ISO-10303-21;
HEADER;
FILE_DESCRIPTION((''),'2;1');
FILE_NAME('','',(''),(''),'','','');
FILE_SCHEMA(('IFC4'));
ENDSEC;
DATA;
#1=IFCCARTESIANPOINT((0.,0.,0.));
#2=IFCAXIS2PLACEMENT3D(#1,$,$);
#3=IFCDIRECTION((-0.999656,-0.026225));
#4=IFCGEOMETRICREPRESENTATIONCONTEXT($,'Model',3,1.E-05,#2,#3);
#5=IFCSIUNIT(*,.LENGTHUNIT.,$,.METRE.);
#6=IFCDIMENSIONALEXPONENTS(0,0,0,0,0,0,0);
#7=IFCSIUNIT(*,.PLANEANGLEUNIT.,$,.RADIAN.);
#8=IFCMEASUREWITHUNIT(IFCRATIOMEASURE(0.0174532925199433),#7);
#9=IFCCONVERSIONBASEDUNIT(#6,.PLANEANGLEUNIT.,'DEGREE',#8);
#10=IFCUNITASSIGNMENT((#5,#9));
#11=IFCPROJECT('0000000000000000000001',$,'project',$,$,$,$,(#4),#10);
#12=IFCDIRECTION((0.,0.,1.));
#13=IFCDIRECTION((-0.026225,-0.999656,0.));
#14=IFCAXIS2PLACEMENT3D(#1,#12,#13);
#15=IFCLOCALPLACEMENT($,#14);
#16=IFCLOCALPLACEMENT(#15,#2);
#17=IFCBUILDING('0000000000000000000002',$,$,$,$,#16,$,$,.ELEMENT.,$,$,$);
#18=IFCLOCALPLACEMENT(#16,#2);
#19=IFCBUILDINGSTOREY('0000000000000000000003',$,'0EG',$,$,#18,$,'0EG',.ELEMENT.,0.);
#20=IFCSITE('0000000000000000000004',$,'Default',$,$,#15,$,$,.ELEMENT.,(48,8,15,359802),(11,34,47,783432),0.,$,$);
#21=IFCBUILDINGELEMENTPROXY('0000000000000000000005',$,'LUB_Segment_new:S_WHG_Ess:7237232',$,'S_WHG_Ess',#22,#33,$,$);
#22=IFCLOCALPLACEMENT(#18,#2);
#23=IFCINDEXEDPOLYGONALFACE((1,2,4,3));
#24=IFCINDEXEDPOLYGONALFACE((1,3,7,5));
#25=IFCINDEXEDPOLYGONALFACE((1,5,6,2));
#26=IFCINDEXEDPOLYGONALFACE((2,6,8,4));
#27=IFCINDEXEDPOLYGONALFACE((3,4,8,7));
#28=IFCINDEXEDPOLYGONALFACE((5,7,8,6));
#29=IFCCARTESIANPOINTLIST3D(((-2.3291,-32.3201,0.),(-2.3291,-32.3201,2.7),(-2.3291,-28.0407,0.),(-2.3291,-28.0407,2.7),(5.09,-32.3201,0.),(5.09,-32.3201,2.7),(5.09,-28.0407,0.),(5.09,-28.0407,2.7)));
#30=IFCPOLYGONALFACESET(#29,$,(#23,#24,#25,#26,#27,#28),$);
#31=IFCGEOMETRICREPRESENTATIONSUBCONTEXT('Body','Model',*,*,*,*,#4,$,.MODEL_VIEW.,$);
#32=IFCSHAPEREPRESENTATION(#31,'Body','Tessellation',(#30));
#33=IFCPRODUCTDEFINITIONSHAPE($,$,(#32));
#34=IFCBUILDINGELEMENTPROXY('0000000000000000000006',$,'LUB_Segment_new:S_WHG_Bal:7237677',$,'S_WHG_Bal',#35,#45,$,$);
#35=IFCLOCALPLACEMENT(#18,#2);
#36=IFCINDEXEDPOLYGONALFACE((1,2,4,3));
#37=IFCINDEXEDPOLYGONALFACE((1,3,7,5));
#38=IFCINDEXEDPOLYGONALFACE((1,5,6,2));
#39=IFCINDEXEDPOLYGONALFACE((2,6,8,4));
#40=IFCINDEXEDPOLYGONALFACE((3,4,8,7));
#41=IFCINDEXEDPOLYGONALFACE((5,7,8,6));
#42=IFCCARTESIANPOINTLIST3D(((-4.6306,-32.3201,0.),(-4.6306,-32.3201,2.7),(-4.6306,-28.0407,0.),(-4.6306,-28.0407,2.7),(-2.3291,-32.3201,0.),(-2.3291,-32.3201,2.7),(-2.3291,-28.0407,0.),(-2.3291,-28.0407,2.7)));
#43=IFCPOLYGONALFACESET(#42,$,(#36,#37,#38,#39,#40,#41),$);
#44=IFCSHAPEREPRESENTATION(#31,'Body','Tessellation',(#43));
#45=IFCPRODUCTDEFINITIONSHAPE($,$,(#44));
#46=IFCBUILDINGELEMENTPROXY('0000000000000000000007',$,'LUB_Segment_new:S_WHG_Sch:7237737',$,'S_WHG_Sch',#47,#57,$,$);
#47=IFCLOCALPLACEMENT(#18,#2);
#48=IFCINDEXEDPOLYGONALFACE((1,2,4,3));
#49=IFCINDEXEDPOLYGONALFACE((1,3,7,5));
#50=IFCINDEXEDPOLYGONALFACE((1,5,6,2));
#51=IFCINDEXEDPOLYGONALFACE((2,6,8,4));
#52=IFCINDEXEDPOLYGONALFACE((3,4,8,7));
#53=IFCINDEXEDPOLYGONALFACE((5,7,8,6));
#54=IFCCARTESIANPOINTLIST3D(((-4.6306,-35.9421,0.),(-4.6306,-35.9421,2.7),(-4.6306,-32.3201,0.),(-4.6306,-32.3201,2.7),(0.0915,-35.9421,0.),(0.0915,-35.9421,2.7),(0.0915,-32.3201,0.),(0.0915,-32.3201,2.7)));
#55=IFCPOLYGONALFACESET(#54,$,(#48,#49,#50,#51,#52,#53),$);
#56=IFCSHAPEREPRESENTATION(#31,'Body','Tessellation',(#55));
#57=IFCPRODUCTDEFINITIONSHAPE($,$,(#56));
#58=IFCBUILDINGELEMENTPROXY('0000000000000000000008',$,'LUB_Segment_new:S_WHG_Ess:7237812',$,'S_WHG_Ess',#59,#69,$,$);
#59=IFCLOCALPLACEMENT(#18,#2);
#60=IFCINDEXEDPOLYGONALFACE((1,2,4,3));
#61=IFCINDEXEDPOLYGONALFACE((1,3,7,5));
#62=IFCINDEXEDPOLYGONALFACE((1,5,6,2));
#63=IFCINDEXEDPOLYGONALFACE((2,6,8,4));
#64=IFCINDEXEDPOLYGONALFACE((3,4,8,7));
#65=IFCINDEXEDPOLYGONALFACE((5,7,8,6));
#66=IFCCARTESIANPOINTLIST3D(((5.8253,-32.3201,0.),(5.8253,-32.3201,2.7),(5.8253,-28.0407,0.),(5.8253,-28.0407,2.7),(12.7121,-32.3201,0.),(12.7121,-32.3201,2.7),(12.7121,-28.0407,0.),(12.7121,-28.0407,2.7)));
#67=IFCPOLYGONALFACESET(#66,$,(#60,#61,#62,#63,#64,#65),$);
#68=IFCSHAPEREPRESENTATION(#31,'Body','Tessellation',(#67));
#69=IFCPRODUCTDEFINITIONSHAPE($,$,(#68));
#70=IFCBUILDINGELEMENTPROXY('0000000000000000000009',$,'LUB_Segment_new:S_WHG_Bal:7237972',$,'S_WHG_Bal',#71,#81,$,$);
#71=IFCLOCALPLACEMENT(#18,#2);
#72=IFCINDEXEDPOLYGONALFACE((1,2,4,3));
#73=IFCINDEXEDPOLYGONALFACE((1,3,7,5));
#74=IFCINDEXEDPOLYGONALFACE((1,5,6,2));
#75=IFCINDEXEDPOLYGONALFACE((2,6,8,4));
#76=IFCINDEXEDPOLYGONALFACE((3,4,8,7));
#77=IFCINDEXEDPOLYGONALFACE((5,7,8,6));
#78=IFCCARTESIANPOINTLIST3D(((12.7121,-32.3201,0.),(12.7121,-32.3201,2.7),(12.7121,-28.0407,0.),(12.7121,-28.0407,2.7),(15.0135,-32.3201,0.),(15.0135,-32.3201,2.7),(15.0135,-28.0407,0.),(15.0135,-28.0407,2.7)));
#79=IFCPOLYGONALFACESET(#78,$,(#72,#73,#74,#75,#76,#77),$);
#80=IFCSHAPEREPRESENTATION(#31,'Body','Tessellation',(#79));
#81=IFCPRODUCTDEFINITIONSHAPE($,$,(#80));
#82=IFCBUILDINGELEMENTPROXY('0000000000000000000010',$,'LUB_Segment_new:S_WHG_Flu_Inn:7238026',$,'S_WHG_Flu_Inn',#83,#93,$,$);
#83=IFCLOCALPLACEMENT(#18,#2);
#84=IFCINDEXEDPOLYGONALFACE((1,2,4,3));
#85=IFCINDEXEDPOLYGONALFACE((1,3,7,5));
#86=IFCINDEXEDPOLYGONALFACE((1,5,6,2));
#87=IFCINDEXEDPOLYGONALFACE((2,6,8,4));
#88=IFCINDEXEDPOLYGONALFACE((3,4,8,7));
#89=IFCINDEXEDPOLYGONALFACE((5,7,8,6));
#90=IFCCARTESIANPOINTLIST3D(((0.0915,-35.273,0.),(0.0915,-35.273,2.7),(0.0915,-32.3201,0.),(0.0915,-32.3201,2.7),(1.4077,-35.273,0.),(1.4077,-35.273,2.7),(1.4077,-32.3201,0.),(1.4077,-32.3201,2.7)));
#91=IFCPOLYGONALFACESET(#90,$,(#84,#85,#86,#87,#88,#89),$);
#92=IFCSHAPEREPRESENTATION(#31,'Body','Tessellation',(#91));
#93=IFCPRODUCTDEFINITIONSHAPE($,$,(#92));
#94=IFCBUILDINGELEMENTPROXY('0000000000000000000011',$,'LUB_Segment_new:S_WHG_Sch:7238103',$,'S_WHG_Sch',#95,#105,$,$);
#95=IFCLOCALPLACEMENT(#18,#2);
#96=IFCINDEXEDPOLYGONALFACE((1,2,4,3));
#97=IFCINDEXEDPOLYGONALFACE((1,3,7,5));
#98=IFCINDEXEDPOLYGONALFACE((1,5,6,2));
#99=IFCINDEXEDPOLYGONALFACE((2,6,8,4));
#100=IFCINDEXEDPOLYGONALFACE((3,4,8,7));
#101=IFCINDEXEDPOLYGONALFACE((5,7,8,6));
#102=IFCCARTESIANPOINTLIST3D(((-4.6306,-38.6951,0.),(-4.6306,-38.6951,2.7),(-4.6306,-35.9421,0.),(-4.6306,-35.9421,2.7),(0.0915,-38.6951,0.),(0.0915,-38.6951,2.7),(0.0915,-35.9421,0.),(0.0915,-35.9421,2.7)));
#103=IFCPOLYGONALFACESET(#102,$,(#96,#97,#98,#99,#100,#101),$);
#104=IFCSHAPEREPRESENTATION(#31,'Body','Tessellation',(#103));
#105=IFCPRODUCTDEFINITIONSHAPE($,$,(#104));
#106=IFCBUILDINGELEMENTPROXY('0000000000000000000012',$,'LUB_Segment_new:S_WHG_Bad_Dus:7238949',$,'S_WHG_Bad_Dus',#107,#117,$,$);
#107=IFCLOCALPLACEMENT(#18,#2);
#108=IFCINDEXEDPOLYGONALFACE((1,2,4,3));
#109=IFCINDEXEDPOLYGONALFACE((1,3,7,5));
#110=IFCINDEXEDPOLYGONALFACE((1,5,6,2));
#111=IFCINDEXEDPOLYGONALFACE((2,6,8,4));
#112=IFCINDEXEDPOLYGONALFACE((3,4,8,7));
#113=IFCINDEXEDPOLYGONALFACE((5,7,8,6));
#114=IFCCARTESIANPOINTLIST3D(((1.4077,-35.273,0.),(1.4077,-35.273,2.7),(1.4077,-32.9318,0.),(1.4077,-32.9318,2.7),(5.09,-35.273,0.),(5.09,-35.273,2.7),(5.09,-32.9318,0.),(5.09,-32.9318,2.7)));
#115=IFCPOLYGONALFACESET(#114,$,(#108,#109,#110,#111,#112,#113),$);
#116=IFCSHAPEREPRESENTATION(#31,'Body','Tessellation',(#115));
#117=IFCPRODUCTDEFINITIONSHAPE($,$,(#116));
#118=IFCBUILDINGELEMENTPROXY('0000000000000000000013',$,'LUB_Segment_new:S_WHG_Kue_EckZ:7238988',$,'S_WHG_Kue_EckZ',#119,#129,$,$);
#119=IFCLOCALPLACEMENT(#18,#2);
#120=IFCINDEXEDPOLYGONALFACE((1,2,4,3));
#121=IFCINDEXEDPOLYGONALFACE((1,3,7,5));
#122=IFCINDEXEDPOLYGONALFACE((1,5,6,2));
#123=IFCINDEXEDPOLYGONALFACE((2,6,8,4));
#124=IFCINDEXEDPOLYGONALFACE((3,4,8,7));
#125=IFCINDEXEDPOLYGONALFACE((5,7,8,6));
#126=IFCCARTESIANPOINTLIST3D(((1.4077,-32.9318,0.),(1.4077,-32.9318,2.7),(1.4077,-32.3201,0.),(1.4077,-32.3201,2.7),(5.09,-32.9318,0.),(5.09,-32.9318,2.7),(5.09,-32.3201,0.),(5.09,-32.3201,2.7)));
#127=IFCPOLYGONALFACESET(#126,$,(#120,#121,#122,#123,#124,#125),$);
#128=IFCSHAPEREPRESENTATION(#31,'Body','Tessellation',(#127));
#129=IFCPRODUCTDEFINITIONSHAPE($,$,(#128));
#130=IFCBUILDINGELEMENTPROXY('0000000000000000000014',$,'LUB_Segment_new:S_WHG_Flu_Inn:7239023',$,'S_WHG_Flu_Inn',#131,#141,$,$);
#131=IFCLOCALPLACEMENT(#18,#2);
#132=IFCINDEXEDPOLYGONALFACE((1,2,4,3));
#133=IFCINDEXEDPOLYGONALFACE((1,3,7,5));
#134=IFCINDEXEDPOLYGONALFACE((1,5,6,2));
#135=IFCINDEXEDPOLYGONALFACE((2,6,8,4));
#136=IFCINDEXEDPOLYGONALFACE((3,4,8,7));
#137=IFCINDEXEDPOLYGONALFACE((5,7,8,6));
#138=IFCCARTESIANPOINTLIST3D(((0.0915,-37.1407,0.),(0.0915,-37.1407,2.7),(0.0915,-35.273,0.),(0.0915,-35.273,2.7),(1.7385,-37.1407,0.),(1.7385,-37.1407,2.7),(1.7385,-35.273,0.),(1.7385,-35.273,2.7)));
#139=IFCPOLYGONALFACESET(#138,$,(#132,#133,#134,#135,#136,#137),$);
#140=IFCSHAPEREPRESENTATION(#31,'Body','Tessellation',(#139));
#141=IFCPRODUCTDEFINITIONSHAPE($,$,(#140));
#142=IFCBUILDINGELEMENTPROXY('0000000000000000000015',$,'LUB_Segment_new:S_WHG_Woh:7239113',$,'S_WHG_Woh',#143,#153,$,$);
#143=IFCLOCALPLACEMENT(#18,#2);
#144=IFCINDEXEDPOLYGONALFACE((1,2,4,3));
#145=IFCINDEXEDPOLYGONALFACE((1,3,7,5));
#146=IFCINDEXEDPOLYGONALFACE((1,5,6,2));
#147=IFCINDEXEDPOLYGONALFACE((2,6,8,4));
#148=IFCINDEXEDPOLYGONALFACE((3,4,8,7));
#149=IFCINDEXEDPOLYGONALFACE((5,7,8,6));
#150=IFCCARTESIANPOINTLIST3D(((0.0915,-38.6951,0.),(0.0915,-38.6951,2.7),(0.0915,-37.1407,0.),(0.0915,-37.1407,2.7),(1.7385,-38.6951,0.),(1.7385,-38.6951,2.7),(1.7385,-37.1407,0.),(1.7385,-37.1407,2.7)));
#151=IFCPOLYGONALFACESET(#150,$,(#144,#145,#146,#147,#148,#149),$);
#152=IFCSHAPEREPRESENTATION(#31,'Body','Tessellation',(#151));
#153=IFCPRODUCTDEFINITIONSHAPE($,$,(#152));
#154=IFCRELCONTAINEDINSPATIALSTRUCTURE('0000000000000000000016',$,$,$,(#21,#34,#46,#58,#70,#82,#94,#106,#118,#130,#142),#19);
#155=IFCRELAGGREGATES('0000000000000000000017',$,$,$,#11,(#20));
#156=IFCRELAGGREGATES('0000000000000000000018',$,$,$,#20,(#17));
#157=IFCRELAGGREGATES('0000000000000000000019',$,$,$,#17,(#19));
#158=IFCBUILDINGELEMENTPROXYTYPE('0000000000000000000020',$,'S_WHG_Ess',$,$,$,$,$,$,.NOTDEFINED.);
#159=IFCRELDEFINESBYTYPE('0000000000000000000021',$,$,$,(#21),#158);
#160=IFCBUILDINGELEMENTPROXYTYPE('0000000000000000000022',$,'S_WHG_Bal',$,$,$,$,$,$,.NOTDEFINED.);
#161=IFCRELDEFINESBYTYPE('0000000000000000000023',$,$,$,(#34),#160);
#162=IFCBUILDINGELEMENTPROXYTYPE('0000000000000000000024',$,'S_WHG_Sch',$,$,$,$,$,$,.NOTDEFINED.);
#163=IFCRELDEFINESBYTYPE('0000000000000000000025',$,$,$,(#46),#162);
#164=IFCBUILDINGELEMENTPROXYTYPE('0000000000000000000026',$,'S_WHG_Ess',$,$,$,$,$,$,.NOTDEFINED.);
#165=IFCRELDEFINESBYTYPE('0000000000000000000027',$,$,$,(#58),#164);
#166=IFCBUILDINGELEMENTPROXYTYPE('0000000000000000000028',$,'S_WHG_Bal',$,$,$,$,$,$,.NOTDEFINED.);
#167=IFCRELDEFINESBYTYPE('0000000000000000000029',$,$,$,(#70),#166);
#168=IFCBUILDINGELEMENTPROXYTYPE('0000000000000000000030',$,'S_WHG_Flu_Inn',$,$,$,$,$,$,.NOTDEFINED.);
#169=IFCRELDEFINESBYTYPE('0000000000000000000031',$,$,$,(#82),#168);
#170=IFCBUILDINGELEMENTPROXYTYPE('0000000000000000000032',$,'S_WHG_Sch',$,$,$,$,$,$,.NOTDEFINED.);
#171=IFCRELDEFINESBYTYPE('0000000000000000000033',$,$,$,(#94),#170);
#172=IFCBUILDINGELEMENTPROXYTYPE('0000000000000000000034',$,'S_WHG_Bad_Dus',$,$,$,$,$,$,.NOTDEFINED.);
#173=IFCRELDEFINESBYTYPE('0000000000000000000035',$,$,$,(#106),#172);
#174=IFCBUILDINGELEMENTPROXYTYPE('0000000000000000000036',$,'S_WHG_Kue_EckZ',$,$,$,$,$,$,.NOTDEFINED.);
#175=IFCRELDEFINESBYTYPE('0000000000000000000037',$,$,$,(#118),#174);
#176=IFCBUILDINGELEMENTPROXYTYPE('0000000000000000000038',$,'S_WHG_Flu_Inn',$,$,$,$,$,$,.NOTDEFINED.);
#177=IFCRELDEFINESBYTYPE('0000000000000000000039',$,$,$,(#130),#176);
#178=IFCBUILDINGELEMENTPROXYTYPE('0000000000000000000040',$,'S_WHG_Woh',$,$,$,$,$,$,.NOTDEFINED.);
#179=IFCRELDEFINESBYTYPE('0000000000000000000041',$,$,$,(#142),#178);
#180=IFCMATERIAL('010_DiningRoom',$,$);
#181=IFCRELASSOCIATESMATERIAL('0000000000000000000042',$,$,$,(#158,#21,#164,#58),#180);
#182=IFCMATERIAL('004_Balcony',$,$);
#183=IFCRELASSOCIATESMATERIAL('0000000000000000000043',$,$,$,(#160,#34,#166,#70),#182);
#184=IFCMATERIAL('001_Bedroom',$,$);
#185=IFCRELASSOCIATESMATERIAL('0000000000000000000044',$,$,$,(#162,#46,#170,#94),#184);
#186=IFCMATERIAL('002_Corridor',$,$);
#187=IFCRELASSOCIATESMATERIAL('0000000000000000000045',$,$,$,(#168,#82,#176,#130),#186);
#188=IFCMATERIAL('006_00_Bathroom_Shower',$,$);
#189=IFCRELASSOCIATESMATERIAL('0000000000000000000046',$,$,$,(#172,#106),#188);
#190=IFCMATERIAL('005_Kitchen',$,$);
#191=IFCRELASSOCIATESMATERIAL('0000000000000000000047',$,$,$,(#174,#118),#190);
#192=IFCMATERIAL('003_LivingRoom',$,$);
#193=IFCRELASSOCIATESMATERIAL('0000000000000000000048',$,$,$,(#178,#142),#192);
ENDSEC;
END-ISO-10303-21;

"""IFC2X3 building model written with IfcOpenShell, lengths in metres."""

from ifc_helpers import new_model, entity, si_unit, converted_unit, direction, frame, origin, origin_2d_with_axis, place, context, subcontext, project, spatial, rectangle, extrude, source, transform, mapped, material, type_object, type_shapes, element, save


model = new_model("IFC2X3")

# Units and contexts
model_context = context("Model", 3, precision=1e-05, world=origin(), true_north=direction((-0.999656, -0.026225)))
body_context = subcontext(model_context, "Body", "Model", "MODEL_VIEW")
ifc_project = project(units=[si_unit("LENGTHUNIT", "METRE"), converted_unit("PLANEANGLEUNIT", "DEGREE", entity("IfcRatioMeasure", 0.0174532925199433), si_unit("PLANEANGLEUNIT", "RADIAN"), dimensions=[0, 0, 0, 0, 0, 0, 0])], contexts=[model_context])

# Site, building, storey
site_placement = place(None, frame((0.0, 0.0, 0.0), z_axis=(0.0, 0.0, 1.0), x_axis=(-0.026225, -0.999656, 0.0)))
site = spatial("IfcSite", under=ifc_project, at=site_placement, Name="Default", CompositionType="ELEMENT", RefLatitude=(48, 8, 15, 359802), RefLongitude=(11, 34, 47, 783432), RefElevation=0.0)
building_placement = place(site_placement, origin())
building = spatial("IfcBuilding", under=site, at=building_placement, CompositionType="ELEMENT")
storey_placement = place(building_placement, origin())
storey = spatial("IfcBuildingStorey", under=building, at=storey_placement, Name="0EG", LongName="0EG", CompositionType="ELEMENT", Elevation=0.0)

# Building element proxies
ifc_material_1 = material(Name="010_DiningRoom")
building_element_proxy_type_1 = type_object("IfcBuildingElementProxyType", Name="S_WHG_Ess", PredefinedType="NOTDEFINED", material=ifc_material_1)
shared_shape_1 = source(origin(), body_context, "Body", "SweptSolid", [
    extrude(rectangle(XDim=7.4191, YDim=4.2794, at=origin_2d_with_axis()), frame((0.0, 0.0, 0.0), z_axis=(0.0, 0.0, 1.0), x_axis=(-1.0, 0.0, 0.0)), (0.0, 0.0, 1.0), 2.7),
])
type_shapes(building_element_proxy_type_1, [shared_shape_1])
proxy_1_placement = place(storey_placement, frame((1.3805, -30.1804, 0.0)))
element("IfcBuildingElementProxy", 1, at=proxy_1_placement, inside=storey, type_object=building_element_proxy_type_1, material=ifc_material_1, Name="LUB_Segment_new:S_WHG_Ess:7237232", ObjectType="S_WHG_Ess", context=body_context, shape_type="MappedRepresentation", body=[
    mapped(shared_shape_1, transform((0.0, 0.0, 0.0), scale=1.0)),
])
ifc_material_2 = material(Name="004_Balcony")
building_element_proxy_type_2 = type_object("IfcBuildingElementProxyType", Name="S_WHG_Bal", PredefinedType="NOTDEFINED", material=ifc_material_2)
shared_shape_2 = source(origin(), body_context, "Body", "SweptSolid", [
    extrude(rectangle(XDim=2.3015, YDim=4.2794, at=origin_2d_with_axis()), frame((0.0, 0.0, 0.0), z_axis=(0.0, 0.0, 1.0), x_axis=(-1.0, 0.0, 0.0)), (0.0, 0.0, 1.0), 2.7),
])
type_shapes(building_element_proxy_type_2, [shared_shape_2])
proxy_2_placement = place(storey_placement, frame((-3.4798, -30.1804, 0.0)))
element("IfcBuildingElementProxy", 2, at=proxy_2_placement, inside=storey, type_object=building_element_proxy_type_2, material=ifc_material_2, Name="LUB_Segment_new:S_WHG_Bal:7237677", ObjectType="S_WHG_Bal", context=body_context, shape_type="MappedRepresentation", body=[
    mapped(shared_shape_2, transform((0.0, 0.0, 0.0), scale=1.0)),
])
ifc_material_3 = material(Name="001_Bedroom")
building_element_proxy_type_3 = type_object("IfcBuildingElementProxyType", Name="S_WHG_Sch", PredefinedType="NOTDEFINED", material=ifc_material_3)
shared_shape_3 = source(origin(), body_context, "Body", "SweptSolid", [
    extrude(rectangle(XDim=4.7221, YDim=3.6221, at=origin_2d_with_axis()), frame((0.0, 0.0, 0.0), z_axis=(0.0, 0.0, 1.0), x_axis=(-1.0, 0.0, 0.0)), (0.0, 0.0, 1.0), 2.7),
])
type_shapes(building_element_proxy_type_3, [shared_shape_3])
proxy_3_placement = place(storey_placement, frame((-2.2695, -34.1311, 0.0)))
element("IfcBuildingElementProxy", 3, at=proxy_3_placement, inside=storey, type_object=building_element_proxy_type_3, material=ifc_material_3, Name="LUB_Segment_new:S_WHG_Sch:7237737", ObjectType="S_WHG_Sch", context=body_context, shape_type="MappedRepresentation", body=[
    mapped(shared_shape_3, transform((0.0, 0.0, 0.0), scale=1.0)),
])
building_element_proxy_type_4 = type_object("IfcBuildingElementProxyType", Name="S_WHG_Ess", PredefinedType="NOTDEFINED", material=ifc_material_1)
shared_shape_4 = source(origin(), body_context, "Body", "SweptSolid", [
    extrude(rectangle(XDim=6.8868, YDim=4.2794, at=origin_2d_with_axis()), frame((0.0, 0.0, 0.0), z_axis=(0.0, 0.0, 1.0), x_axis=(-1.0, 0.0, 0.0)), (0.0, 0.0, 1.0), 2.7),
])
type_shapes(building_element_proxy_type_4, [shared_shape_4])
proxy_4_placement = place(storey_placement, frame((9.2687, -30.1804, 0.0)))
element("IfcBuildingElementProxy", 4, at=proxy_4_placement, inside=storey, type_object=building_element_proxy_type_4, material=ifc_material_1, Name="LUB_Segment_new:S_WHG_Ess:7237812", ObjectType="S_WHG_Ess", context=body_context, shape_type="MappedRepresentation", body=[
    mapped(shared_shape_4, transform((0.0, 0.0, 0.0), scale=1.0)),
])
building_element_proxy_type_5 = type_object("IfcBuildingElementProxyType", Name="S_WHG_Bal", PredefinedType="NOTDEFINED", material=ifc_material_2)
shared_shape_5 = source(origin(), body_context, "Body", "SweptSolid", [
    extrude(rectangle(XDim=4.2794, YDim=2.3015, at=origin_2d_with_axis()), frame((0.0, 0.0, 0.0), z_axis=(0.0, 0.0, 1.0), x_axis=(0.0, 1.0, 0.0)), (0.0, 0.0, 1.0), 2.7),
])
type_shapes(building_element_proxy_type_5, [shared_shape_5])
proxy_5_placement = place(storey_placement, frame((13.8628, -30.1804, 0.0), z_axis=(0.0, 0.0, 1.0), x_axis=(-1.0, 0.0, 0.0)))
element("IfcBuildingElementProxy", 5, at=proxy_5_placement, inside=storey, type_object=building_element_proxy_type_5, material=ifc_material_2, Name="LUB_Segment_new:S_WHG_Bal:7237972", ObjectType="S_WHG_Bal", context=body_context, shape_type="MappedRepresentation", body=[
    mapped(shared_shape_5, transform((0.0, 0.0, 0.0), scale=1.0)),
])
ifc_material_4 = material(Name="002_Corridor")
building_element_proxy_type_6 = type_object("IfcBuildingElementProxyType", Name="S_WHG_Flu_Inn", PredefinedType="NOTDEFINED", material=ifc_material_4)
shared_shape_6 = source(origin(), body_context, "Body", "SweptSolid", [
    extrude(rectangle(XDim=1.3162, YDim=2.9529, at=origin_2d_with_axis()), frame((0.0, 0.0, 0.0), z_axis=(0.0, 0.0, 1.0), x_axis=(-1.0, 0.0, 0.0)), (0.0, 0.0, 1.0), 2.7),
])
type_shapes(building_element_proxy_type_6, [shared_shape_6])
proxy_6_placement = place(storey_placement, frame((0.7496, -33.7966, 0.0)))
element("IfcBuildingElementProxy", 6, at=proxy_6_placement, inside=storey, type_object=building_element_proxy_type_6, material=ifc_material_4, Name="LUB_Segment_new:S_WHG_Flu_Inn:7238026", ObjectType="S_WHG_Flu_Inn", context=body_context, shape_type="MappedRepresentation", body=[
    mapped(shared_shape_6, transform((0.0, 0.0, 0.0), scale=1.0)),
])
building_element_proxy_type_7 = type_object("IfcBuildingElementProxyType", Name="S_WHG_Sch", PredefinedType="NOTDEFINED", material=ifc_material_3)
shared_shape_7 = source(origin(), body_context, "Body", "SweptSolid", [
    extrude(rectangle(XDim=4.7221, YDim=2.7529, at=origin_2d_with_axis()), frame((0.0, 0.0, 0.0), z_axis=(0.0, 0.0, 1.0), x_axis=(-1.0, 0.0, 0.0)), (0.0, 0.0, 1.0), 2.7),
])
type_shapes(building_element_proxy_type_7, [shared_shape_7])
proxy_7_placement = place(storey_placement, frame((-2.2695, -37.3186, 0.0)))
element("IfcBuildingElementProxy", 7, at=proxy_7_placement, inside=storey, type_object=building_element_proxy_type_7, material=ifc_material_3, Name="LUB_Segment_new:S_WHG_Sch:7238103", ObjectType="S_WHG_Sch", context=body_context, shape_type="MappedRepresentation", body=[
    mapped(shared_shape_7, transform((0.0, 0.0, 0.0), scale=1.0)),
])
ifc_material_5 = material(Name="006_00_Bathroom_Shower")
building_element_proxy_type_8 = type_object("IfcBuildingElementProxyType", Name="S_WHG_Bad_Dus", PredefinedType="NOTDEFINED", material=ifc_material_5)
shared_shape_8 = source(origin(), body_context, "Body", "SweptSolid", [
    extrude(rectangle(XDim=2.3412, YDim=3.6824, at=origin_2d_with_axis()), frame((0.0, 0.0, 0.0), z_axis=(0.0, 0.0, 1.0), x_axis=(0.0, 1.0, 0.0)), (0.0, 0.0, 1.0), 2.7),
])
type_shapes(building_element_proxy_type_8, [shared_shape_8])
proxy_8_placement = place(storey_placement, frame((3.2488, -34.1024, 0.0)))
element("IfcBuildingElementProxy", 8, at=proxy_8_placement, inside=storey, type_object=building_element_proxy_type_8, material=ifc_material_5, Name="LUB_Segment_new:S_WHG_Bad_Dus:7238949", ObjectType="S_WHG_Bad_Dus", context=body_context, shape_type="MappedRepresentation", body=[
    mapped(shared_shape_8, transform((0.0, 0.0, 0.0), scale=1.0)),
])
ifc_material_6 = material(Name="005_Kitchen")
building_element_proxy_type_9 = type_object("IfcBuildingElementProxyType", Name="S_WHG_Kue_EckZ", PredefinedType="NOTDEFINED", material=ifc_material_6)
shared_shape_9 = source(origin(), body_context, "Body", "SweptSolid", [
    extrude(rectangle(XDim=0.6118, YDim=3.6824, at=origin_2d_with_axis()), frame((0.0, 0.0, 0.0), z_axis=(0.0, 0.0, 1.0), x_axis=(0.0, 1.0, 0.0)), (0.0, 0.0, 1.0), 2.7),
])
type_shapes(building_element_proxy_type_9, [shared_shape_9])
proxy_9_placement = place(storey_placement, frame((3.2488, -32.626, 0.0)))
element("IfcBuildingElementProxy", 9, at=proxy_9_placement, inside=storey, type_object=building_element_proxy_type_9, material=ifc_material_6, Name="LUB_Segment_new:S_WHG_Kue_EckZ:7238988", ObjectType="S_WHG_Kue_EckZ", context=body_context, shape_type="MappedRepresentation", body=[
    mapped(shared_shape_9, transform((0.0, 0.0, 0.0), scale=1.0)),
])
building_element_proxy_type_10 = type_object("IfcBuildingElementProxyType", Name="S_WHG_Flu_Inn", PredefinedType="NOTDEFINED", material=ifc_material_4)
shared_shape_10 = source(origin(), body_context, "Body", "SweptSolid", [
    extrude(rectangle(XDim=1.6471, YDim=1.8676, at=origin_2d_with_axis()), frame((0.0, 0.0, 0.0), z_axis=(0.0, 0.0, 1.0), x_axis=(-1.0, 0.0, 0.0)), (0.0, 0.0, 1.0), 2.7),
])
type_shapes(building_element_proxy_type_10, [shared_shape_10])
proxy_10_placement = place(storey_placement, frame((0.915, -36.2068, 0.0)))
element("IfcBuildingElementProxy", 10, at=proxy_10_placement, inside=storey, type_object=building_element_proxy_type_10, material=ifc_material_4, Name="LUB_Segment_new:S_WHG_Flu_Inn:7239023", ObjectType="S_WHG_Flu_Inn", context=body_context, shape_type="MappedRepresentation", body=[
    mapped(shared_shape_10, transform((0.0, 0.0, 0.0), scale=1.0)),
])
ifc_material_7 = material(Name="003_LivingRoom")
building_element_proxy_type_11 = type_object("IfcBuildingElementProxyType", Name="S_WHG_Woh", PredefinedType="NOTDEFINED", material=ifc_material_7)
shared_shape_11 = source(origin(), body_context, "Body", "SweptSolid", [
    extrude(rectangle(XDim=1.6471, YDim=1.5544, at=origin_2d_with_axis()), frame((0.0, 0.0, 0.0), z_axis=(0.0, 0.0, 1.0), x_axis=(-1.0, 0.0, 0.0)), (0.0, 0.0, 1.0), 2.7),
])
type_shapes(building_element_proxy_type_11, [shared_shape_11])
proxy_11_placement = place(storey_placement, frame((0.915, -37.9179, 0.0)))
element("IfcBuildingElementProxy", 11, at=proxy_11_placement, inside=storey, type_object=building_element_proxy_type_11, material=ifc_material_7, Name="LUB_Segment_new:S_WHG_Woh:7239113", ObjectType="S_WHG_Woh", context=body_context, shape_type="MappedRepresentation", body=[
    mapped(shared_shape_11, transform((0.0, 0.0, 0.0), scale=1.0)),
])

save(model, "model.ifc")
